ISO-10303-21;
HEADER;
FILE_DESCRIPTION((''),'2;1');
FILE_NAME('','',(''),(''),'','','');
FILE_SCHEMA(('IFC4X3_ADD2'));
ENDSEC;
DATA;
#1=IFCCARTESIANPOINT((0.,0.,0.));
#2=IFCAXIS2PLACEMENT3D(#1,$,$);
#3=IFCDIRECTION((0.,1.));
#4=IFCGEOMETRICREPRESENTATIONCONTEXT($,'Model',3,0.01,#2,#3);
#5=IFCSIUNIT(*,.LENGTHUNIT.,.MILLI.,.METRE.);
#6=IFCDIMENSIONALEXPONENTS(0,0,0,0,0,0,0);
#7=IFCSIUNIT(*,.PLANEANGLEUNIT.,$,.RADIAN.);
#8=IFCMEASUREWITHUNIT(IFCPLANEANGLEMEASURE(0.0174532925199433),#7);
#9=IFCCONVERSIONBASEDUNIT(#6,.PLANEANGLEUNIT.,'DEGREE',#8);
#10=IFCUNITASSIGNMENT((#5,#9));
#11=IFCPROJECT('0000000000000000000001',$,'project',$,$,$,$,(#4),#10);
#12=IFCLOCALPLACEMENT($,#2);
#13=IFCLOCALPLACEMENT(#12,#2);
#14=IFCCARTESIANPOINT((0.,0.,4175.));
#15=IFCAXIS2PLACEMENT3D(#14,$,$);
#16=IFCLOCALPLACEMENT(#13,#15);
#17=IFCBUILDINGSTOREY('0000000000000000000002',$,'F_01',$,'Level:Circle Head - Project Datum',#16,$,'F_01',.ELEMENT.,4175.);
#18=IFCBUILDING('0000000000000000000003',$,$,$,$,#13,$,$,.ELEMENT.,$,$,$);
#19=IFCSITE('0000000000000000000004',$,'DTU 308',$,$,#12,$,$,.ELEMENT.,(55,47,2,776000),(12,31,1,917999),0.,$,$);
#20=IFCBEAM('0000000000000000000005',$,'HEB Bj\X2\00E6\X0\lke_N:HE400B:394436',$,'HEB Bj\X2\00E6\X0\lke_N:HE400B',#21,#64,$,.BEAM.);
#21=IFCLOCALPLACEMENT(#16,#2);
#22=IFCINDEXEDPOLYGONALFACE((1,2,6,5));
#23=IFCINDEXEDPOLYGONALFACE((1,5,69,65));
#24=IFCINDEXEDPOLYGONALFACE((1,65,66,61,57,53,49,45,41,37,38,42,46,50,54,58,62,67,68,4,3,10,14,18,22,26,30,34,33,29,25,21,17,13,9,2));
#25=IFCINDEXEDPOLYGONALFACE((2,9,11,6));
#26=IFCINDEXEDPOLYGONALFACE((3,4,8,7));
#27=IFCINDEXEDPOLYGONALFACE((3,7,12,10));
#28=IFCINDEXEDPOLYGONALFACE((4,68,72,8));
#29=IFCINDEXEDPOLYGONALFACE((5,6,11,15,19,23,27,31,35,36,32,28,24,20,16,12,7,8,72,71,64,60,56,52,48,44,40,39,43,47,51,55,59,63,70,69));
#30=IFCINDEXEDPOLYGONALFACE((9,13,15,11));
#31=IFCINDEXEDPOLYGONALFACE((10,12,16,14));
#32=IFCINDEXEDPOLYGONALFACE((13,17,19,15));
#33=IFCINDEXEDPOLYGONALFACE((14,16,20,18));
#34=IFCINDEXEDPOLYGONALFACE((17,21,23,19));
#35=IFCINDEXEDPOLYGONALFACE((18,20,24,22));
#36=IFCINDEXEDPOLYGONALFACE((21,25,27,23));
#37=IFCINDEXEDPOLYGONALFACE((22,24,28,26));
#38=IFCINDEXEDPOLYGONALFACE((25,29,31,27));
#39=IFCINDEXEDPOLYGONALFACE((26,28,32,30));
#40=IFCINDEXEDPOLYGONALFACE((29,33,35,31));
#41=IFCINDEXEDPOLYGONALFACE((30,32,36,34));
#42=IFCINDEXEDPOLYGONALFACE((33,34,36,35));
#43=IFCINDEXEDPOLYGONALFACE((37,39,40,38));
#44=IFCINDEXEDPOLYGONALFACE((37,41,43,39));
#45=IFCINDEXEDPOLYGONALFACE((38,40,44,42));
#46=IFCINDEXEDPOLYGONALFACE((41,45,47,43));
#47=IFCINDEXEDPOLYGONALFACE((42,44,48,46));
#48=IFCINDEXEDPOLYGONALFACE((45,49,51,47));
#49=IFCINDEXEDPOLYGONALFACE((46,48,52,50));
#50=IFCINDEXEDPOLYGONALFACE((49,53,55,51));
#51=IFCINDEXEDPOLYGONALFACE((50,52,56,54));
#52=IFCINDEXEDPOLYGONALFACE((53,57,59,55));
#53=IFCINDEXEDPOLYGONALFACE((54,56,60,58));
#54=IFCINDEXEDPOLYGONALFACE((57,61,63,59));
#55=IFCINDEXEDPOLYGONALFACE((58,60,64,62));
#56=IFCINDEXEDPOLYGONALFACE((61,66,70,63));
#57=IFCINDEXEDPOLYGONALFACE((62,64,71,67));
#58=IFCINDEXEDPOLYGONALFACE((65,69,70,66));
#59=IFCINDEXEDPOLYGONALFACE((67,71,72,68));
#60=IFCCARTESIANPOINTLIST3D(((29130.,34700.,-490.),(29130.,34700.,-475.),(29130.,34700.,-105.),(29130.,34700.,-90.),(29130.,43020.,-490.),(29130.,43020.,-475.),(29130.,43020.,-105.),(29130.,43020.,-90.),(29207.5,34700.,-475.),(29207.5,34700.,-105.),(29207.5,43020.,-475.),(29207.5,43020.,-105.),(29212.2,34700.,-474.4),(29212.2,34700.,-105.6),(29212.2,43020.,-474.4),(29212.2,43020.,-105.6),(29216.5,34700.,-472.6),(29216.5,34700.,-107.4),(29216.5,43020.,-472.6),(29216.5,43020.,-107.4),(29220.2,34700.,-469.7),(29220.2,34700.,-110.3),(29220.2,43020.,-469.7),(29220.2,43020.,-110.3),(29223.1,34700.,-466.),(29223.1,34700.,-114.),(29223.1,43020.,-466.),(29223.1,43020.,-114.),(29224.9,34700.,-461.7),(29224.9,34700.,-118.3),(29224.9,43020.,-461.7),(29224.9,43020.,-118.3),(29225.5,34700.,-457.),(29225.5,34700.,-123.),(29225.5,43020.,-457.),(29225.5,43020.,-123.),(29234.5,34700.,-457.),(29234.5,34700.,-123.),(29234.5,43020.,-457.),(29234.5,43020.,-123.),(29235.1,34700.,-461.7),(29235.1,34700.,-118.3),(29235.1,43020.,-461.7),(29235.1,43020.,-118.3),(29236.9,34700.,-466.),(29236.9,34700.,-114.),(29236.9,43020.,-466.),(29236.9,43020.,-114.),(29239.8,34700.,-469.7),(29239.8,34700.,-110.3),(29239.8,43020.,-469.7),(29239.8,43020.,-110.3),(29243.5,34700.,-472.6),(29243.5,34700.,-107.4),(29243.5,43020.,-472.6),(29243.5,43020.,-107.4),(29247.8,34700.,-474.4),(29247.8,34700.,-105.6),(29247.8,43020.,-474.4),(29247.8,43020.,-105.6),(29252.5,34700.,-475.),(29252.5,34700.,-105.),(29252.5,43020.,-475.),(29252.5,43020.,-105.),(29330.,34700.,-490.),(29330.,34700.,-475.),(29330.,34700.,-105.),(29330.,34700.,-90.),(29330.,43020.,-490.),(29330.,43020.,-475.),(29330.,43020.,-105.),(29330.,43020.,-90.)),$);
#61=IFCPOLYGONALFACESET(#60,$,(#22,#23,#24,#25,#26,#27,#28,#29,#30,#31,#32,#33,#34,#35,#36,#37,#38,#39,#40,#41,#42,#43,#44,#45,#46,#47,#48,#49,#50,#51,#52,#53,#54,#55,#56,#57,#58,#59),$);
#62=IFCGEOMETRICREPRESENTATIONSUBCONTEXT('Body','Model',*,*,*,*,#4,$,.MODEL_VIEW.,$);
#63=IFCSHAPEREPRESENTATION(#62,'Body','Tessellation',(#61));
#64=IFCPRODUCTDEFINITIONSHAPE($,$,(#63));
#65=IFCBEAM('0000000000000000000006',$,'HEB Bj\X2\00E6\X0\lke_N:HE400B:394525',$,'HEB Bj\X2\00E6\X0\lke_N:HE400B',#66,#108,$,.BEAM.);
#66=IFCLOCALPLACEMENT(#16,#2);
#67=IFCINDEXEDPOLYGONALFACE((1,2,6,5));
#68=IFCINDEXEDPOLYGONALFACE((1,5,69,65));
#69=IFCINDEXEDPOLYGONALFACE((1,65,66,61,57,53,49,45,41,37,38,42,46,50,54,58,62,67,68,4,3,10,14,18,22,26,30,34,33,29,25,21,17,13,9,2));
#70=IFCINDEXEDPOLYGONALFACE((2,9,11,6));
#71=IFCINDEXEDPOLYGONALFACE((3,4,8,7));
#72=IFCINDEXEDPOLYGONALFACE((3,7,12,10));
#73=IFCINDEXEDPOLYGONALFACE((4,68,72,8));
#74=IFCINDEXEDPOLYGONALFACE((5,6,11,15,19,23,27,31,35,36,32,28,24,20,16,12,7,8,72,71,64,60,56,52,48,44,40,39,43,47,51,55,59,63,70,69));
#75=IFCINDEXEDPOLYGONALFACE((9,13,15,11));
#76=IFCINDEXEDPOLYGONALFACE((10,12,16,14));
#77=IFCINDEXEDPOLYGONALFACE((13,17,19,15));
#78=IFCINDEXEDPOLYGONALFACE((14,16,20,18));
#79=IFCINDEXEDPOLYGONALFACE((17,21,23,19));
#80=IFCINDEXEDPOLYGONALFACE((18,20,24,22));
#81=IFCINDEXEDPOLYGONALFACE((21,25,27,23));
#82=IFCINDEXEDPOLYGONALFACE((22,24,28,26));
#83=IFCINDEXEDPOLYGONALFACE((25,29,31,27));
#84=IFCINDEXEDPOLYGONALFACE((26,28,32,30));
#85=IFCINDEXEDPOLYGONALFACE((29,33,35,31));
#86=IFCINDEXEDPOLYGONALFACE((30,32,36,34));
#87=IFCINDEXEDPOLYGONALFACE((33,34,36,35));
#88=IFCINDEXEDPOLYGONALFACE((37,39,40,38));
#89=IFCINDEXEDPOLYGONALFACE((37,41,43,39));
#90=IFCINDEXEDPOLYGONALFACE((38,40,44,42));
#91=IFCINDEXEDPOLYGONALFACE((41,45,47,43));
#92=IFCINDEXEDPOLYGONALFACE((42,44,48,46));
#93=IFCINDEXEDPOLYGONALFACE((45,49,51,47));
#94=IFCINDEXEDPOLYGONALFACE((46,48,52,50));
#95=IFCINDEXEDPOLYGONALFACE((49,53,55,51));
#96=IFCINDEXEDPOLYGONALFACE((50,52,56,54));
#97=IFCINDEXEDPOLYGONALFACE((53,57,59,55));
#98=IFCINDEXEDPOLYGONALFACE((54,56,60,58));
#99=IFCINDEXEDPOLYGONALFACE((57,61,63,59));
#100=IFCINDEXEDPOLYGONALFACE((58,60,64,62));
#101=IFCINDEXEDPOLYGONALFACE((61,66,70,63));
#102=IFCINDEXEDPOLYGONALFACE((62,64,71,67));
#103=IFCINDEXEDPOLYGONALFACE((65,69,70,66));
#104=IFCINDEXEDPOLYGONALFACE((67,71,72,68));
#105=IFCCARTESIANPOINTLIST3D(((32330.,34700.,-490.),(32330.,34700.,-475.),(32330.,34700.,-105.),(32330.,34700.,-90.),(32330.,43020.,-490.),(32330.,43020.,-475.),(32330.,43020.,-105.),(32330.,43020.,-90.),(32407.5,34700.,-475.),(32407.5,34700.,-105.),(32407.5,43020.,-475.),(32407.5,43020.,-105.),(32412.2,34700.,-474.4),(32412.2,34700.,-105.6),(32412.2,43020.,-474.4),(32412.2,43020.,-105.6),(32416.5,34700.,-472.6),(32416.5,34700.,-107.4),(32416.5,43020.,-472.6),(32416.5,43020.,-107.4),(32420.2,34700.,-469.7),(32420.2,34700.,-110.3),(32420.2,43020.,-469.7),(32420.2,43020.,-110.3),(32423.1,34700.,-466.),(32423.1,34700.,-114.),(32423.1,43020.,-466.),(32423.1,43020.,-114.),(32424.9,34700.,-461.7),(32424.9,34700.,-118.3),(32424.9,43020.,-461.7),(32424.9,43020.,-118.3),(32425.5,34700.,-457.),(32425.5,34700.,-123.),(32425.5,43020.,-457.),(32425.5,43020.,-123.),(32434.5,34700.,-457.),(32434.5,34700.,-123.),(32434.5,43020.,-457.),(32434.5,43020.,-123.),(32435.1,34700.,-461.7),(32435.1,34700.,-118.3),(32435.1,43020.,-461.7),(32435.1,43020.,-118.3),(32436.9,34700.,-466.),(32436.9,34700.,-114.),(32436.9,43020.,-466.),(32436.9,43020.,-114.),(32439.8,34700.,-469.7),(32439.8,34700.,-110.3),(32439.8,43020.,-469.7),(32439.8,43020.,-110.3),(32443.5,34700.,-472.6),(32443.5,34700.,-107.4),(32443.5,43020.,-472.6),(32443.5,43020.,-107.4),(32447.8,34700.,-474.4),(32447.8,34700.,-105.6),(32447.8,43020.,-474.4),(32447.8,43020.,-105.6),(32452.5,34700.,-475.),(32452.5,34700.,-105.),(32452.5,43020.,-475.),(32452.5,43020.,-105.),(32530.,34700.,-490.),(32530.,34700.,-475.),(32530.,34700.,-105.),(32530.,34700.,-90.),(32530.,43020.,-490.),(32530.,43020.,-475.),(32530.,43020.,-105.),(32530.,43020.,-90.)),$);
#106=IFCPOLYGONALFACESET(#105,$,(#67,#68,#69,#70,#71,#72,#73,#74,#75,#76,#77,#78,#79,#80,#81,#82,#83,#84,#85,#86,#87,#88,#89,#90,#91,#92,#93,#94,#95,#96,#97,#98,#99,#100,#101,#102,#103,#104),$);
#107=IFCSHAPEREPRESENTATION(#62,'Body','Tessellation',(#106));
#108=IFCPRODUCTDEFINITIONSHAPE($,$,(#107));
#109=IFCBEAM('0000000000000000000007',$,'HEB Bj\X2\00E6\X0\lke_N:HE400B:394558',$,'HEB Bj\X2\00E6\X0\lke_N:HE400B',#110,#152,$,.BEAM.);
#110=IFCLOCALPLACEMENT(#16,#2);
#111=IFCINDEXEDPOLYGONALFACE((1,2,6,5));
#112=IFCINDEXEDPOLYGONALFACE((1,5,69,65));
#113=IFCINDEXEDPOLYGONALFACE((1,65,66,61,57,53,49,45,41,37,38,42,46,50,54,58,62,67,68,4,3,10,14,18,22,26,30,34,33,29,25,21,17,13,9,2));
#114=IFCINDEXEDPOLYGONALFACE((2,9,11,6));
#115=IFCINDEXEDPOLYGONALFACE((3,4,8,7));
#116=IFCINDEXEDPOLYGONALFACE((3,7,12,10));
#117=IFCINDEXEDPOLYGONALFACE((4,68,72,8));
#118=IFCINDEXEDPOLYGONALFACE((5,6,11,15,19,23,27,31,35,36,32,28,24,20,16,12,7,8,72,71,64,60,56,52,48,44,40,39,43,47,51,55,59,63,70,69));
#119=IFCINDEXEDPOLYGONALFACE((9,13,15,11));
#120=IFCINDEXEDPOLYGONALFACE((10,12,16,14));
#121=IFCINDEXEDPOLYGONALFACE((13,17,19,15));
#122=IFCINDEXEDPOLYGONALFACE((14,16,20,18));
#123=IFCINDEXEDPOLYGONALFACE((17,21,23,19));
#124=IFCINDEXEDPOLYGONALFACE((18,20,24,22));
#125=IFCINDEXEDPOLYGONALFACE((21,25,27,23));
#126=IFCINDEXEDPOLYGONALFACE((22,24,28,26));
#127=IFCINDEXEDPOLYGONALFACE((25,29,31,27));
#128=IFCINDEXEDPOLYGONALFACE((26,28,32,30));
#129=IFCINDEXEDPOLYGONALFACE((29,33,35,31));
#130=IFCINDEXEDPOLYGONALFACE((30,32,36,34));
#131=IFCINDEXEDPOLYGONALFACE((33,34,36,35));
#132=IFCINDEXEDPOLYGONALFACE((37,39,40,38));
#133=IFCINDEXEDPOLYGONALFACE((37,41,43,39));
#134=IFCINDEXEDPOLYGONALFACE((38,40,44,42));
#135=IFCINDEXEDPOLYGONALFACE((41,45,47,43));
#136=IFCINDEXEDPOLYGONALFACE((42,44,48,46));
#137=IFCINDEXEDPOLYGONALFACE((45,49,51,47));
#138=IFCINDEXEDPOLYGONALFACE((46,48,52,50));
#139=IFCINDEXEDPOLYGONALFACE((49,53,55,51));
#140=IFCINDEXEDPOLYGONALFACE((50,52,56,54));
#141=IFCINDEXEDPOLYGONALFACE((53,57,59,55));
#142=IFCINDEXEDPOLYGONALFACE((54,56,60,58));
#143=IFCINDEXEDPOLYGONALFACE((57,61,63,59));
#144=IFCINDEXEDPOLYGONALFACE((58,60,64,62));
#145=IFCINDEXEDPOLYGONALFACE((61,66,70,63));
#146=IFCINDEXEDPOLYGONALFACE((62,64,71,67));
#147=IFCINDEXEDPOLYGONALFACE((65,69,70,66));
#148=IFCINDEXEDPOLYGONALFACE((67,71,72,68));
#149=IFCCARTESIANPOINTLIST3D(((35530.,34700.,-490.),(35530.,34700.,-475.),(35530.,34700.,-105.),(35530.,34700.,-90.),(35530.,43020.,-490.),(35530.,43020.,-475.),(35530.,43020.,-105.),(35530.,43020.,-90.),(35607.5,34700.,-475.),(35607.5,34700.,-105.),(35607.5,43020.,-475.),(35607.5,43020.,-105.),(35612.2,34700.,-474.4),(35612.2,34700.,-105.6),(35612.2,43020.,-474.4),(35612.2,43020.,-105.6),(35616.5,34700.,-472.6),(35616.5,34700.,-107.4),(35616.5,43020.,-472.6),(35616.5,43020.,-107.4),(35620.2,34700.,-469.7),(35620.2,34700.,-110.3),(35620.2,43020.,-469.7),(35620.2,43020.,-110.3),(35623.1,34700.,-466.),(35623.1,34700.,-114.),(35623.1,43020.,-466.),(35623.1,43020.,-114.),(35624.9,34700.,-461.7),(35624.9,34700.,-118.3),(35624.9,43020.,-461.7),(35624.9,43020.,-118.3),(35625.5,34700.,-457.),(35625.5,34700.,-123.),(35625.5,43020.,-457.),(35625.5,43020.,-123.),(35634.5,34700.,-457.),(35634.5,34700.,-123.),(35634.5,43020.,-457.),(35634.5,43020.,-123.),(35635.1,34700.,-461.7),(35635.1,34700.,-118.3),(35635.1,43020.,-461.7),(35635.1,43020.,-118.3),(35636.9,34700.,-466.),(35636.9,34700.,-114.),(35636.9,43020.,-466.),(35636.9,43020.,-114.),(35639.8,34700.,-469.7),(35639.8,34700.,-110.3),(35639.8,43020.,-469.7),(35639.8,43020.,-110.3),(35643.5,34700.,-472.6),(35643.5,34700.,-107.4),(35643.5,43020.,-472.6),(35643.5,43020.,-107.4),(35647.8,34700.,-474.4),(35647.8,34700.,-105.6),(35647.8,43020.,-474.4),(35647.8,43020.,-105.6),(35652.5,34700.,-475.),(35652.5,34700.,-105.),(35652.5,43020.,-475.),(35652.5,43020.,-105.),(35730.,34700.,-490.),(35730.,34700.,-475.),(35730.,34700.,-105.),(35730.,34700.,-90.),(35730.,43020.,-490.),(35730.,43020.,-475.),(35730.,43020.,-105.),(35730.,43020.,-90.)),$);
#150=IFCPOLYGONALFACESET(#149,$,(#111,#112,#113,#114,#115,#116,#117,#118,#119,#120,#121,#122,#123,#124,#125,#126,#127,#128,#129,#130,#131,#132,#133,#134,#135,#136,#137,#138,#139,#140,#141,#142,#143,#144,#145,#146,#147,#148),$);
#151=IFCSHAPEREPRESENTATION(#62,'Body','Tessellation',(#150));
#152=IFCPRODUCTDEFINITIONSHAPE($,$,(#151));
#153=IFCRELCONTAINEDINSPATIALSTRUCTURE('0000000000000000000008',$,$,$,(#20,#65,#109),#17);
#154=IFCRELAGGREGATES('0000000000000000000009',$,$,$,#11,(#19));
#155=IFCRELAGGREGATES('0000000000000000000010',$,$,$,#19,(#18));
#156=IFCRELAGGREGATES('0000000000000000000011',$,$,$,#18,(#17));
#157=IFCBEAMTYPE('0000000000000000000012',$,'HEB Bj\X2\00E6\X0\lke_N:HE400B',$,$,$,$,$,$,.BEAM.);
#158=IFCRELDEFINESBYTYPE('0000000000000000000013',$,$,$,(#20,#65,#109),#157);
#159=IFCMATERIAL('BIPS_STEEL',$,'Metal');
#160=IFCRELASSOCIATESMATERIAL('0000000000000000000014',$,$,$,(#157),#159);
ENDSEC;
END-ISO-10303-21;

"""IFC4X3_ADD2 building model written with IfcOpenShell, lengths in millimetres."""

from ifc_helpers import new_model, entity, si_unit, converted_unit, direction, frame, frame_2d, origin, place, context, subcontext, project, spatial, polyline, circle_curve, parameter, trimmed, segment, composite_curve, outline, extrude, source, transform, mapped, material, material_profile, profile_set, type_object, element, save


model = new_model("IFC4X3_ADD2")

# Units and contexts
model_context = context("Model", 3, precision=0.01, world=origin(), true_north=direction((0.0, 1.0)))
body_context = subcontext(model_context, "Body", "Model", "MODEL_VIEW")
ifc_project = project(units=[si_unit("LENGTHUNIT", "METRE", prefix="MILLI"), converted_unit("PLANEANGLEUNIT", "DEGREE", entity("IfcPlaneAngleMeasure", 0.0174532925199433), si_unit("PLANEANGLEUNIT", "RADIAN"), dimensions=[0, 0, 0, 0, 0, 0, 0])], contexts=[model_context])

# Site, building, storey
site_placement = place(None, origin())
site = spatial("IfcSite", under=ifc_project, at=site_placement, Name="DTU 308", CompositionType="ELEMENT", RefLatitude=(55, 47, 2, 776000), RefLongitude=(12, 31, 1, 917999), RefElevation=0.0)
building_placement = place(site_placement, origin())
building = spatial("IfcBuilding", under=site, at=building_placement, CompositionType="ELEMENT")
storey_placement = place(building_placement, frame((0.0, 0.0, 4175.0)))
storey = spatial("IfcBuildingStorey", under=building, at=storey_placement, Name="F_01", ObjectType="Level:Circle Head - Project Datum", LongName="F_01", CompositionType="ELEMENT", Elevation=4175.0)

# Shared definitions
ifc_material_1 = material(Name="BIPS_STEEL", Category="Metal")

# Beams
ifc_material_profile_1 = material_profile(ifc_material_1, outline(composite_curve([segment(polyline([(-100.0, -185.0), (-100.0, -200.0)]), True, "CONTINUOUS"), segment(polyline([(-100.0, -200.0), (100.0, -200.0)]), True, "CONTINUOUS"), segment(polyline([(100.0, -200.0), (100.0, -185.0)]), True, "CONTINUOUS"), segment(polyline([(100.0, -185.0), (22.5, -185.0)]), True, "CONTINUOUS"), segment(trimmed(circle_curve(frame_2d((22.5, -167.0), x_axis=(1.0, 0.0)), 18.0), [parameter(180.0)], [parameter(270.0)], True, "PARAMETER"), False, "CONTINUOUS"), segment(polyline([(4.5, -167.0), (4.5, 167.0)]), True, "CONTINUOUS"), segment(trimmed(circle_curve(frame_2d((22.5, 167.0), x_axis=(1.0, 0.0)), 18.0), [parameter(90.0)], [parameter(180.0)], True, "PARAMETER"), False, "CONTINUOUS"), segment(polyline([(22.5, 185.0), (100.0, 185.0)]), True, "CONTINUOUS"), segment(polyline([(100.0, 185.0), (100.0, 200.0)]), True, "CONTINUOUS"), segment(polyline([(100.0, 200.0), (-100.0, 200.0)]), True, "CONTINUOUS"), segment(polyline([(-100.0, 200.0), (-100.0, 185.0)]), True, "CONTINUOUS"), segment(polyline([(-100.0, 185.0), (-22.5, 185.0)]), True, "CONTINUOUS"), segment(trimmed(circle_curve(frame_2d((-22.5, 167.0), x_axis=(1.0, 0.0)), 18.0), [parameter(360.0)], [parameter(90.0)], True, "PARAMETER"), False, "CONTINUOUS"), segment(polyline([(-4.5, 167.0), (-4.5, -167.0)]), True, "CONTINUOUS"), segment(trimmed(circle_curve(frame_2d((-22.5, -167.0), x_axis=(1.0, 0.0)), 18.0), [parameter(270.0)], [parameter(360.0)], True, "PARAMETER"), False, "CONTINUOUS"), segment(polyline([(-22.5, -185.0), (-100.0, -185.0)]), True, "CONTINUOUS")], self_intersect=False)), Name="HE400B")
ifc_profile_set_1 = profile_set([ifc_material_profile_1], Name="HE400B")
beam_type_1 = type_object("IfcBeamType", Name="HEB Bjælke_N:HE400B", PredefinedType="BEAM", material=ifc_profile_set_1)
shared_shape_1 = source(origin(), body_context, "Body", "SweptSolid", [
    extrude(outline(composite_curve([segment(polyline([(-100.0, -185.0), (-100.0, -200.0)]), True, "CONTINUOUS"), segment(polyline([(-100.0, -200.0), (100.0, -200.0)]), True, "CONTINUOUS"), segment(polyline([(100.0, -200.0), (100.0, -185.0)]), True, "CONTINUOUS"), segment(polyline([(100.0, -185.0), (22.5, -185.0)]), True, "CONTINUOUS"), segment(trimmed(circle_curve(frame_2d((22.5, -167.0), x_axis=(1.0, 0.0)), 18.0), [parameter(180.0)], [parameter(270.0)], True, "PARAMETER"), False, "CONTINUOUS"), segment(polyline([(4.5, -167.0), (4.5, 167.0)]), True, "CONTINUOUS"), segment(trimmed(circle_curve(frame_2d((22.5, 167.0), x_axis=(1.0, 0.0)), 18.0), [parameter(90.0)], [parameter(180.0)], True, "PARAMETER"), False, "CONTINUOUS"), segment(polyline([(22.5, 185.0), (100.0, 185.0)]), True, "CONTINUOUS"), segment(polyline([(100.0, 185.0), (100.0, 200.0)]), True, "CONTINUOUS"), segment(polyline([(100.0, 200.0), (-100.0, 200.0)]), True, "CONTINUOUS"), segment(polyline([(-100.0, 200.0), (-100.0, 185.0)]), True, "CONTINUOUS"), segment(polyline([(-100.0, 185.0), (-22.5, 185.0)]), True, "CONTINUOUS"), segment(trimmed(circle_curve(frame_2d((-22.5, 167.0), x_axis=(1.0, 0.0)), 18.0), [parameter(360.0)], [parameter(90.0)], True, "PARAMETER"), False, "CONTINUOUS"), segment(polyline([(-4.5, 167.0), (-4.5, -167.0)]), True, "CONTINUOUS"), segment(trimmed(circle_curve(frame_2d((-22.5, -167.0), x_axis=(1.0, 0.0)), 18.0), [parameter(270.0)], [parameter(360.0)], True, "PARAMETER"), False, "CONTINUOUS"), segment(polyline([(-22.5, -185.0), (-100.0, -185.0)]), True, "CONTINUOUS")], self_intersect=False)), frame((-4060.0, 0.0, 0.0), z_axis=(-1.0, 0.0, 0.0), x_axis=(0.0, -1.0, 0.0)), (0.0, 0.0, -1.0), 8320.0),
])
for number, where, z_axis, x_axis, name in (
    (1, (29230.0, 38960.0, -290.0), (0.0, 0.0, 1.0), (0.0, -1.0, 0.0), "HEB Bjælke_N:HE400B:394436"),
    (2, (32430.0, 38960.0, -290.0), (0.0, 0.0, 1.0), (0.0, -1.0, 0.0), "HEB Bjælke_N:HE400B:394525"),
    (3, (35630.0, 38960.0, -290.0), (0.0, 0.0, 1.0), (0.0, -1.0, 0.0), "HEB Bjælke_N:HE400B:394558"),
):
    element("IfcBeam", number, at=place(storey_placement, frame(where, z_axis=z_axis, x_axis=x_axis)), inside=storey, type_object=beam_type_1, Name=name, ObjectType="HEB Bjælke_N:HE400B", PredefinedType="BEAM", context=body_context, shape_type="MappedRepresentation", body=[
        mapped(shared_shape_1, transform((0.0, 0.0, 0.0), scale=1.0)),
    ])

save(model, "model.ifc")
